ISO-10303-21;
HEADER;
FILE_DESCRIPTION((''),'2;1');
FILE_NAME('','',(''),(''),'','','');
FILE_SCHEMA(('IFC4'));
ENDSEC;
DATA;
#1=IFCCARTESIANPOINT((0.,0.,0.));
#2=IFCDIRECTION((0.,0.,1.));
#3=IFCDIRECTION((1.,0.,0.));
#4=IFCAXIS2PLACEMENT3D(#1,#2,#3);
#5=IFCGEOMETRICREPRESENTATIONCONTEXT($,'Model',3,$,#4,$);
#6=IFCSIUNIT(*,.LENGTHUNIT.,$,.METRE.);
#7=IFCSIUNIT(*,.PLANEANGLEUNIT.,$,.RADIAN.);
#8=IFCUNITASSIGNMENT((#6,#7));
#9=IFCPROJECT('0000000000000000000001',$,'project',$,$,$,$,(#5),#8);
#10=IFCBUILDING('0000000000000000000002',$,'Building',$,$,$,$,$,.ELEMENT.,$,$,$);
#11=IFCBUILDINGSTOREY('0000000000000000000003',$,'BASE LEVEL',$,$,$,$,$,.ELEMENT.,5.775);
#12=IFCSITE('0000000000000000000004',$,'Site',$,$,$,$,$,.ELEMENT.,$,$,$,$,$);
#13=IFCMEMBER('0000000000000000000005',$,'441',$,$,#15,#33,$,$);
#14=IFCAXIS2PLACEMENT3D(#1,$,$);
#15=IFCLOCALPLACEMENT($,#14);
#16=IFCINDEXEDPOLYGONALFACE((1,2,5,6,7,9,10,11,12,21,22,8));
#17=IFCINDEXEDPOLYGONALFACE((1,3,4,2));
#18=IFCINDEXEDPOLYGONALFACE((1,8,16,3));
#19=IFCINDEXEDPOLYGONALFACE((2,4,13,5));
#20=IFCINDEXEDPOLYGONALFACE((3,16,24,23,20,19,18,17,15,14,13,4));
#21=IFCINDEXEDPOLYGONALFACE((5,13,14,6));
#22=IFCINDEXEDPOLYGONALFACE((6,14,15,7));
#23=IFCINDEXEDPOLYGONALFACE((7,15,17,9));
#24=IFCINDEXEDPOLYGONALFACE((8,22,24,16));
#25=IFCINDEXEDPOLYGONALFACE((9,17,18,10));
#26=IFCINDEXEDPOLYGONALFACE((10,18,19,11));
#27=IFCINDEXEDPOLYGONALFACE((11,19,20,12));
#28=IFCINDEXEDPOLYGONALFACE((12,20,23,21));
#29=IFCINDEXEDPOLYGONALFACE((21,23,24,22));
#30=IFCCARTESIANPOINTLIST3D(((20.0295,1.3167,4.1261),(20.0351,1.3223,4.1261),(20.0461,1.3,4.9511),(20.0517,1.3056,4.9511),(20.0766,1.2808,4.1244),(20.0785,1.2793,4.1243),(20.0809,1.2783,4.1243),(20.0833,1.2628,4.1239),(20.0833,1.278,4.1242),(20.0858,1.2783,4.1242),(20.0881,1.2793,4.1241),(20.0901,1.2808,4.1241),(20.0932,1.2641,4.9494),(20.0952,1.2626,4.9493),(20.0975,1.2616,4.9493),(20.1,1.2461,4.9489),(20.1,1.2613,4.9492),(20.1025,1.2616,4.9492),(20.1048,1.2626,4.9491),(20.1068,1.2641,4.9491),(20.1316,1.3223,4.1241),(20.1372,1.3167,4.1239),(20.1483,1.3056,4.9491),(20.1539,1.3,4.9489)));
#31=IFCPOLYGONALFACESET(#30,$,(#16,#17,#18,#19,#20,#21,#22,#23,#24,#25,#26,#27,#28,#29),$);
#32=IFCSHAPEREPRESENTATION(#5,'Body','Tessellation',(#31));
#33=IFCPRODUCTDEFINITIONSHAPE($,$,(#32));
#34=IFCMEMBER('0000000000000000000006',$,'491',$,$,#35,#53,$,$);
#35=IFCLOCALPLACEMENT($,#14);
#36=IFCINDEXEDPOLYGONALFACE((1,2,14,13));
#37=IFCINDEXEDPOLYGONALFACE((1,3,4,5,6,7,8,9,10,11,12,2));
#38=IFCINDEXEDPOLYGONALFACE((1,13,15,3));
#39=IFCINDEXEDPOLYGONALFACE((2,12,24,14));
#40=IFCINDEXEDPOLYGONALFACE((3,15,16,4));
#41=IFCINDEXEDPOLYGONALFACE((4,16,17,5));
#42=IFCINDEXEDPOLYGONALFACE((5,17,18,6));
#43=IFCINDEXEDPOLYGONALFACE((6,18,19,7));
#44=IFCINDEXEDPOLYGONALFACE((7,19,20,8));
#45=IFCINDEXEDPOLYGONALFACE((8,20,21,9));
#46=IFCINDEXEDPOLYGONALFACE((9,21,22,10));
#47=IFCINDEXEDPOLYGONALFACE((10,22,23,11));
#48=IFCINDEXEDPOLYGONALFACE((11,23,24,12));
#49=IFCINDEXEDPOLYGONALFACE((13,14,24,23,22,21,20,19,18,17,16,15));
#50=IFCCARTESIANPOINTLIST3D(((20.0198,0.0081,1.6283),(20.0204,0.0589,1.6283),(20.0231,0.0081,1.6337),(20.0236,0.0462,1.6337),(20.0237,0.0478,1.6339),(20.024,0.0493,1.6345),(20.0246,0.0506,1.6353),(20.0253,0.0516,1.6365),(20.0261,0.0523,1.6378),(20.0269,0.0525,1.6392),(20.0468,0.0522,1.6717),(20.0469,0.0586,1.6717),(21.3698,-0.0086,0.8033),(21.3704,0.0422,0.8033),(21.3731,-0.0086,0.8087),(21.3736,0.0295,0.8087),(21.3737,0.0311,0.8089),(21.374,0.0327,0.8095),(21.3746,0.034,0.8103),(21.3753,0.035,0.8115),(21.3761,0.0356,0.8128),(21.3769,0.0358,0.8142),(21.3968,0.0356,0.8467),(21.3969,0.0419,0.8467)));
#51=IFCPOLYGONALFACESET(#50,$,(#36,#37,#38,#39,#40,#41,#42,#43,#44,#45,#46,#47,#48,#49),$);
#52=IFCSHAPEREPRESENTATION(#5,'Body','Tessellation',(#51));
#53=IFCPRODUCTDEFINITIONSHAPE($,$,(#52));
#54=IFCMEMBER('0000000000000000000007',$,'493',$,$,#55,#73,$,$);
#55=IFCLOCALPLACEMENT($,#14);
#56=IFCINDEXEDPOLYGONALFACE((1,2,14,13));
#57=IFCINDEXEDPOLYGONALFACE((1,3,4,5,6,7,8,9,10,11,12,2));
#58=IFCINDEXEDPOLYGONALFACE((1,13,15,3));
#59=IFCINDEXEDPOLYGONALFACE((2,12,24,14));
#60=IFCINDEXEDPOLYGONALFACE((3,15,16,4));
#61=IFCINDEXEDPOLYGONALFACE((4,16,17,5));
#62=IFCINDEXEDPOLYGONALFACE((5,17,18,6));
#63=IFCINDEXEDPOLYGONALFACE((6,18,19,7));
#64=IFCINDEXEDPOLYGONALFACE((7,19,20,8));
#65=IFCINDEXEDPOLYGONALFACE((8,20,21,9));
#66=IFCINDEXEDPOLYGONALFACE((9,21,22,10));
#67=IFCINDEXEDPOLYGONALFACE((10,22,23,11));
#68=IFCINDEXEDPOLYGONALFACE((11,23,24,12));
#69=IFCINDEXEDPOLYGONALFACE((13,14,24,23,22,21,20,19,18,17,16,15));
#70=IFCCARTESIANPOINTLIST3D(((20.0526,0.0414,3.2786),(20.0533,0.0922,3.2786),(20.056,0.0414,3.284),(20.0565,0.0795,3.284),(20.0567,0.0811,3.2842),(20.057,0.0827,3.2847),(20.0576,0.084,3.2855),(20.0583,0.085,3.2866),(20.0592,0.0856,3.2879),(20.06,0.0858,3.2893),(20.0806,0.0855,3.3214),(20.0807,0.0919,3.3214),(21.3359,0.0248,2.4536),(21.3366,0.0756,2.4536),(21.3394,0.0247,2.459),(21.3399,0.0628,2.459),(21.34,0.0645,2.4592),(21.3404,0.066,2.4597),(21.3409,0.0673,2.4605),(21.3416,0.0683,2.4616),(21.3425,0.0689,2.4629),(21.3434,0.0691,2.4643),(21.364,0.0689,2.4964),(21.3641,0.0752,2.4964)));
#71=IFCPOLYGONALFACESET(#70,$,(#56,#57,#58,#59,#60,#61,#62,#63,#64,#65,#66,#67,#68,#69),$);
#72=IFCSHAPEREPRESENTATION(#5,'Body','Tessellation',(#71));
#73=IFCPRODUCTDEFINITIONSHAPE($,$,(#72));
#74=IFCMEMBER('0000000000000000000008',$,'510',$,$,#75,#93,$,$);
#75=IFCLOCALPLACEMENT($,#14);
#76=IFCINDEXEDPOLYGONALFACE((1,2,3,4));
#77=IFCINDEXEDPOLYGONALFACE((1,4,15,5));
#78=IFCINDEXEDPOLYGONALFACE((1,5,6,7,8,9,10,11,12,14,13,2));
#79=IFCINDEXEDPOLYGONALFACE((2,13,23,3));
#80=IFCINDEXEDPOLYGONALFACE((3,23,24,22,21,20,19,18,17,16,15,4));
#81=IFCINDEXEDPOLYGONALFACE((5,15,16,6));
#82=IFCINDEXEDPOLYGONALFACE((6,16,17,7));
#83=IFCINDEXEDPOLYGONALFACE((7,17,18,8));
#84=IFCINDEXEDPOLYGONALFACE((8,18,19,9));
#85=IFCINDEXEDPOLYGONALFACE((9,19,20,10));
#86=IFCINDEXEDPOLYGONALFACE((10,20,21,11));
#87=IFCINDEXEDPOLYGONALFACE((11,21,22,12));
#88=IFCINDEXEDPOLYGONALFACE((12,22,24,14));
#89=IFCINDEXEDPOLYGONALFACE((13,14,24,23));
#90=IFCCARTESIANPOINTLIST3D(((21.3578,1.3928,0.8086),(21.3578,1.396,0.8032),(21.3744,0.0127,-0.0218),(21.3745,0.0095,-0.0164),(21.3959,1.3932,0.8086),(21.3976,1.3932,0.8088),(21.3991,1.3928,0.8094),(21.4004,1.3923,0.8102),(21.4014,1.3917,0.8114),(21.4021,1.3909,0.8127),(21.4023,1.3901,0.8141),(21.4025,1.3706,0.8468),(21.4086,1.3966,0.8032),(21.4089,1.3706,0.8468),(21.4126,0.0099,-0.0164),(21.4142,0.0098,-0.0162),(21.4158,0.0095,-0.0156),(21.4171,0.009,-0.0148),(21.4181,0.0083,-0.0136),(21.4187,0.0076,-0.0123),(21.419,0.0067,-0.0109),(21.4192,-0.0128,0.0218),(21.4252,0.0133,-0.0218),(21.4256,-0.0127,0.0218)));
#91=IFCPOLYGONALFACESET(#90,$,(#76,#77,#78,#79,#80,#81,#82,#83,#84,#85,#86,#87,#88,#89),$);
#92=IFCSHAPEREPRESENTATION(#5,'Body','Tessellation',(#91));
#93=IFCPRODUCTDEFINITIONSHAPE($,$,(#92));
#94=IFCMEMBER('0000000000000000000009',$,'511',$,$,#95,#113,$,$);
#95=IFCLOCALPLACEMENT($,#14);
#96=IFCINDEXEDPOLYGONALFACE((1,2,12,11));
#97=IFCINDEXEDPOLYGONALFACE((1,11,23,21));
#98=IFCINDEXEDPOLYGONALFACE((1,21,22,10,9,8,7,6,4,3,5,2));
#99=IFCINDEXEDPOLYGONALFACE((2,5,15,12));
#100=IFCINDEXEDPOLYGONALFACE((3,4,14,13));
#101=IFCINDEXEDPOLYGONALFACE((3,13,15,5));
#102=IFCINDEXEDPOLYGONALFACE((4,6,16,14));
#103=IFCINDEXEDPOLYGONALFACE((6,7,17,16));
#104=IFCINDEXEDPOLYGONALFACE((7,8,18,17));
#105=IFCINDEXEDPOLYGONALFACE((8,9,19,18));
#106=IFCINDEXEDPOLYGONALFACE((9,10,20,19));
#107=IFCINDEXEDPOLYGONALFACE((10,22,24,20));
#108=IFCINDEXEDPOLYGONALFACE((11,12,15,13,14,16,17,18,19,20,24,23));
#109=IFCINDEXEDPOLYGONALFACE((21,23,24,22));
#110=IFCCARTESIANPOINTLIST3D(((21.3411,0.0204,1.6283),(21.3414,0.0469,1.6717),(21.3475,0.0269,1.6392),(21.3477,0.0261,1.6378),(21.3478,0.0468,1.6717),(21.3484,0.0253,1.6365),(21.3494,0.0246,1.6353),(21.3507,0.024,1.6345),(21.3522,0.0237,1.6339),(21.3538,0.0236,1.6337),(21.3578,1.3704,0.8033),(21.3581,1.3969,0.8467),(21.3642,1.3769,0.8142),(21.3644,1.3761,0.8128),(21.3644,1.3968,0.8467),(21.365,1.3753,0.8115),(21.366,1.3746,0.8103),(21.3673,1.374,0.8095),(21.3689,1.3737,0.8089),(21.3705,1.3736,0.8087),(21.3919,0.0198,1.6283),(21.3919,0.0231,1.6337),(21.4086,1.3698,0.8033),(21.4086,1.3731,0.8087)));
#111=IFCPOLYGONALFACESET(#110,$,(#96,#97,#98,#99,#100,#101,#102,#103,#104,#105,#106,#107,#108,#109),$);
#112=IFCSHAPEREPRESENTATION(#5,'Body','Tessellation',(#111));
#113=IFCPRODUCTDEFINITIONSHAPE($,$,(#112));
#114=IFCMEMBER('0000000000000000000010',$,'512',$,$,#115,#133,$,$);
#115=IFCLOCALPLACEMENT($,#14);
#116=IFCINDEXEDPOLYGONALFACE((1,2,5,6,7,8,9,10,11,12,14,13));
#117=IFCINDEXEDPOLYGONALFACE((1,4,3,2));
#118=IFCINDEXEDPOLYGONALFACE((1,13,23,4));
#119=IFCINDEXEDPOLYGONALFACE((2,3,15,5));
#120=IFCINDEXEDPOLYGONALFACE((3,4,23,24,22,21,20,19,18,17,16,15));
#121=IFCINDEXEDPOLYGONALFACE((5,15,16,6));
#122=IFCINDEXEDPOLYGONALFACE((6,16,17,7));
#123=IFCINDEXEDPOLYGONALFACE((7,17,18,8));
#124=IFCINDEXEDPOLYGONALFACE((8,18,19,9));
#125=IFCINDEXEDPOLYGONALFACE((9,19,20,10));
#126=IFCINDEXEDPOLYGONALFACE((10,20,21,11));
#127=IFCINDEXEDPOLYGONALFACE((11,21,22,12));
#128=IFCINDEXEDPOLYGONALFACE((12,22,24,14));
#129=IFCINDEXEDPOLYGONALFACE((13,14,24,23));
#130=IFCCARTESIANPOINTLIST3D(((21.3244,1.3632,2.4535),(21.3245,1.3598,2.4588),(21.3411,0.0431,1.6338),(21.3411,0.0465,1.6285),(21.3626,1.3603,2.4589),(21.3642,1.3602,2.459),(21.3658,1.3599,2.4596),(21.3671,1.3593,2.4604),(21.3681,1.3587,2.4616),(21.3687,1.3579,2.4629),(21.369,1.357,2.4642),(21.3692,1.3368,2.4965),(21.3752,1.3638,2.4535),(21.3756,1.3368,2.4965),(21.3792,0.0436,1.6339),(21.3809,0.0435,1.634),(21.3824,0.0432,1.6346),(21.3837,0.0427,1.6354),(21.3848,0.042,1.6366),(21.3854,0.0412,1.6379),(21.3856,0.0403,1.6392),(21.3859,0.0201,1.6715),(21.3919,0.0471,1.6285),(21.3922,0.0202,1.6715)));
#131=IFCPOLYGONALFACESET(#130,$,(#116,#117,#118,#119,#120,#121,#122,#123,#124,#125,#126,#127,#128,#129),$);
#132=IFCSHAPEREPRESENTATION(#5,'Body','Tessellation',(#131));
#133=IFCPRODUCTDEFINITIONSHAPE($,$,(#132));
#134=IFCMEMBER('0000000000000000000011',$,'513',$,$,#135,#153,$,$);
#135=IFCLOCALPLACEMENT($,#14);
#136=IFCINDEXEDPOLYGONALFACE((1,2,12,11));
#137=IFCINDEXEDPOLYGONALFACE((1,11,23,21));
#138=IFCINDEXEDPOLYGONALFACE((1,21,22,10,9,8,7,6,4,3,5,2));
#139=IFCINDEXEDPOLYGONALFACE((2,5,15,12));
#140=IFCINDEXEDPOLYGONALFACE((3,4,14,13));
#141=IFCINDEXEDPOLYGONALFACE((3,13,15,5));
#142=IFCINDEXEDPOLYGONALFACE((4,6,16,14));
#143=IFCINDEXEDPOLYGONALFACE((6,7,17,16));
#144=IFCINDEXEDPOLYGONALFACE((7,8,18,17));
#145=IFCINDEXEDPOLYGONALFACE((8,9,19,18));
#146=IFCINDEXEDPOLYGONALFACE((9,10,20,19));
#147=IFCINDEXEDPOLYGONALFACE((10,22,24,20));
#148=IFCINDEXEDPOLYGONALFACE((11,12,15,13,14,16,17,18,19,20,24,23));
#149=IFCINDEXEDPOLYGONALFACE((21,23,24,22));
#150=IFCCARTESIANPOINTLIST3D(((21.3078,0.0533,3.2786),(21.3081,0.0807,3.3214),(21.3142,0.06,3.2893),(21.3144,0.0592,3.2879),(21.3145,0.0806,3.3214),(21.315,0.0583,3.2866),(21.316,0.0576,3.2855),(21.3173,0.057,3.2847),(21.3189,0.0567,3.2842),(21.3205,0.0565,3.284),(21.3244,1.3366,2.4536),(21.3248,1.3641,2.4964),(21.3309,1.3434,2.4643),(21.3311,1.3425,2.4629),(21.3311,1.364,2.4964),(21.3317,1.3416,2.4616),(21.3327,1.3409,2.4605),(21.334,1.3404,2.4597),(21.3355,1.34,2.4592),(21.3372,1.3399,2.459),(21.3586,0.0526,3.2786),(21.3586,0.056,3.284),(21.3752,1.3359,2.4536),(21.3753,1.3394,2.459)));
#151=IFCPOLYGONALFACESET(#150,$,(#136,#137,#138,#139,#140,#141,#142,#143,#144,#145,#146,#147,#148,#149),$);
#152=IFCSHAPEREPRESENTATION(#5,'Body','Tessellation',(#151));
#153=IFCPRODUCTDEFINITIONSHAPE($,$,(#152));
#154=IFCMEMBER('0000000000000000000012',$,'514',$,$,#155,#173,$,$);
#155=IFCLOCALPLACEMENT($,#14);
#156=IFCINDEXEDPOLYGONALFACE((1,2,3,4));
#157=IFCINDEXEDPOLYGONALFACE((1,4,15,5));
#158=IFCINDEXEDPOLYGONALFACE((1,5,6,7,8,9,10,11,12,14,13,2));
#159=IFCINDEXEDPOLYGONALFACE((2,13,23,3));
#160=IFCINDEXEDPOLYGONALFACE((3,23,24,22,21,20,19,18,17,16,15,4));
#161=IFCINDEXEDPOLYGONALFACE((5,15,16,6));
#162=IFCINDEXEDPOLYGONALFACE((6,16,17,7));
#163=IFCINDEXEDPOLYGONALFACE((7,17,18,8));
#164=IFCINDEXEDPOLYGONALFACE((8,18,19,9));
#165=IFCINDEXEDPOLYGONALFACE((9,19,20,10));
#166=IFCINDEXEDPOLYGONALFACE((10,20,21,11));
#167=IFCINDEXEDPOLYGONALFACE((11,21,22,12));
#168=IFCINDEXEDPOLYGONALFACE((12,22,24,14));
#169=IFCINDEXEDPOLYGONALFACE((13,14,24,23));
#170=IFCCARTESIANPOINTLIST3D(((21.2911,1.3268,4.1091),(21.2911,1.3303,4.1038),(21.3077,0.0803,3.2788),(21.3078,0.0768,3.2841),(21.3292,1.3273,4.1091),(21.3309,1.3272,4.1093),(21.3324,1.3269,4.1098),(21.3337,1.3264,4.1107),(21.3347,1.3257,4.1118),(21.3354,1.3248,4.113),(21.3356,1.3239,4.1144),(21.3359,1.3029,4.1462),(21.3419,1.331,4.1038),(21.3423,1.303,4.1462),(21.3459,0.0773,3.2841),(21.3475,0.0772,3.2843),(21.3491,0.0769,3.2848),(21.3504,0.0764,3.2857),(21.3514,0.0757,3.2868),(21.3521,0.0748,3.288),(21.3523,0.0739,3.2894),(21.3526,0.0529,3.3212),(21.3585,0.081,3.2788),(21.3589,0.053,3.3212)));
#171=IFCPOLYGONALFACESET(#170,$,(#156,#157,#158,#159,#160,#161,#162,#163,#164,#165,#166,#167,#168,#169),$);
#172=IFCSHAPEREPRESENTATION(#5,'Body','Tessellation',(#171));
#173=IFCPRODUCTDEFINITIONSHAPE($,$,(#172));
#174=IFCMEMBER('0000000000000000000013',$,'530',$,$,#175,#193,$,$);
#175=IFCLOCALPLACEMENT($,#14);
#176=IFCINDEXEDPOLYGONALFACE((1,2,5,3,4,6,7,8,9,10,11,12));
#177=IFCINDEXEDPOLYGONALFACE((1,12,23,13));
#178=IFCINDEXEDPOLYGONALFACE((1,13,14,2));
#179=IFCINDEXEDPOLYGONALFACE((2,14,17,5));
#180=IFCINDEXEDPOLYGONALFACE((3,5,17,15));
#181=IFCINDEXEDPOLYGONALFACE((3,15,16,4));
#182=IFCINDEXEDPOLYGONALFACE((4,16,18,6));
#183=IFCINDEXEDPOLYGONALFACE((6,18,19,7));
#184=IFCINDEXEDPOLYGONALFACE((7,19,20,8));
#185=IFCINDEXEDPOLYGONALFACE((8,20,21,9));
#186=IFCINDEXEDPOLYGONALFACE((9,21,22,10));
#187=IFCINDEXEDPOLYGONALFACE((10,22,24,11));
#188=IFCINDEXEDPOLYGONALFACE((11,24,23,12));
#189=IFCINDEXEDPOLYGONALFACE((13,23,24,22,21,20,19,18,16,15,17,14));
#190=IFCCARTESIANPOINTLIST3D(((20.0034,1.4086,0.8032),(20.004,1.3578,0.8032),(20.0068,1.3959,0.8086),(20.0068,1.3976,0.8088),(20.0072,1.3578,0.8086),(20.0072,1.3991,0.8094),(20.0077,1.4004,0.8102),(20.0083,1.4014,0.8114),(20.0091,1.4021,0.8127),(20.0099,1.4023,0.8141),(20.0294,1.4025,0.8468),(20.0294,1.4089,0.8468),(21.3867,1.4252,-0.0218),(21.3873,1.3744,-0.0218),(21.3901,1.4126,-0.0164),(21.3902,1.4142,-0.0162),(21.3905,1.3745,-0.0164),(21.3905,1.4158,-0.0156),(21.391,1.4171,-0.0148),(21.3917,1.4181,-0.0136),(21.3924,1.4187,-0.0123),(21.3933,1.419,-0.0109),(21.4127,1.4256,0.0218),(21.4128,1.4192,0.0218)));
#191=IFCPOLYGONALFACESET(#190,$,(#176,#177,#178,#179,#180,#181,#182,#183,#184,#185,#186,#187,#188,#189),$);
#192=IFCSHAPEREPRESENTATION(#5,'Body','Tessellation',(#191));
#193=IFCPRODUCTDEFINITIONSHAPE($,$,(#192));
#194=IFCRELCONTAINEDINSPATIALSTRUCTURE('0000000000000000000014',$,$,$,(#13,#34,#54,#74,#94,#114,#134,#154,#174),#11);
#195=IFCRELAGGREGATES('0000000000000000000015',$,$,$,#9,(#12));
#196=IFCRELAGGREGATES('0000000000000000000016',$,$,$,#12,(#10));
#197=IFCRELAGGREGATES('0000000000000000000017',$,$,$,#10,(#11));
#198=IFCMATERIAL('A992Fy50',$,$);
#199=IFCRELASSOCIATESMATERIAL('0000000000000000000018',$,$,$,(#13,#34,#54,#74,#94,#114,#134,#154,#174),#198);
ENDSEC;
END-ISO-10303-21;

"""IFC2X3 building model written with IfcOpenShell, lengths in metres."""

from ifc_helpers import new_model, si_unit, frame, origin_with_axes, origin_2d_with_axis, place, context, project, spatial, l_section, extrude, material, element, save


model = new_model("IFC2X3")

# Units and contexts
model_context = context("Model", 3, world=origin_with_axes())
ifc_project = project(units=[si_unit("LENGTHUNIT", "METRE"), si_unit("PLANEANGLEUNIT", "RADIAN")], contexts=[model_context])

# Site, building, storey
site = spatial("IfcSite", under=ifc_project, Name="Site", CompositionType="ELEMENT")
building = spatial("IfcBuilding", under=site, Name="Building", CompositionType="ELEMENT")
storey = spatial("IfcBuildingStorey", under=building, Name="BASE LEVEL", CompositionType="ELEMENT", Elevation=5.775)

# Members
ifc_material = material(Name="A992Fy50")
for number, where, z_axis, x_axis, name in (
    (1, (20.0833, 1.3167, 4.125), (0.020194, -0.020194, 0.999592), (0.707107, 0.707107, 0.0), "441"),
):
    element("IfcMember", number, at=place(None, frame(where, z_axis=z_axis, x_axis=x_axis)), inside=storey, material=ifc_material, Name=name, context=model_context, shape_type="SweptSolid", body=[
        extrude(l_section(Depth=0.0762, Width=0.0762, Thickness=0.0079, FilletRadius=0.0096, at=origin_2d_with_axis()), origin_with_axes(), (0.0, 0.0, 1.0), 0.8253),
    ])
member_1_placement = place(None, frame((21.3833, 0.0167, 0.825), z_axis=(-0.853234, 0.010534, 0.521421), x_axis=(-0.012345, -0.999924, 0.0)))
element("IfcMember", 2, at=member_1_placement, inside=storey, material=ifc_material, Name="491", context=model_context, shape_type="SweptSolid", body=[
    extrude(l_section(Depth=0.0508, Width=0.0508, Thickness=0.0063, FilletRadius=0.0063, at=origin_2d_with_axis()), origin_with_axes(), (0.0, 0.0, 1.0), 1.5822),
])
member_2_placement = place(None, frame((21.35, 0.05, 2.475), z_axis=(-0.841128, 0.010924, 0.540725), x_axis=(-0.012345, -0.999924, 0.0)))
element("IfcMember", 3, at=member_2_placement, inside=storey, material=ifc_material, Name="493", context=model_context, shape_type="SweptSolid", body=[
    extrude(l_section(Depth=0.0508, Width=0.0508, Thickness=0.0063, FilletRadius=0.0063, at=origin_2d_with_axis()), origin_with_axes(), (0.0, 0.0, 1.0), 1.5257),
])
member_3_placement = place(None, frame((21.4, 0.0, 0.0), z_axis=(-0.010347, 0.858813, 0.512184), x_axis=(-0.999927, -0.012047, 0.0)))
element("IfcMember", 4, at=member_3_placement, inside=storey, material=ifc_material, Name="510", context=model_context, shape_type="SweptSolid", body=[
    extrude(l_section(Depth=0.0508, Width=0.0508, Thickness=0.0063, FilletRadius=0.0063, at=origin_2d_with_axis()), origin_with_axes(), (0.0, 0.0, 1.0), 1.6107),
])
member_4_placement = place(None, frame((21.3833, 1.3833, 0.825), z_axis=(-0.010534, -0.853234, 0.521421), x_axis=(0.999924, -0.012345, 0.0)))
element("IfcMember", 5, at=member_4_placement, inside=storey, material=ifc_material, Name="511", context=model_context, shape_type="SweptSolid", body=[
    extrude(l_section(Depth=0.0508, Width=0.0508, Thickness=0.0063, FilletRadius=0.0063, at=origin_2d_with_axis()), origin_with_axes(), (0.0, 0.0, 1.0), 1.5822),
])
member_5_placement = place(None, frame((21.3667, 0.0333, 1.65), z_axis=(-0.010726, 0.847346, 0.530932), x_axis=(-0.999927, -0.012047, 0.0)))
element("IfcMember", 6, at=member_5_placement, inside=storey, material=ifc_material, Name="512", context=model_context, shape_type="SweptSolid", body=[
    extrude(l_section(Depth=0.0508, Width=0.0508, Thickness=0.0063, FilletRadius=0.0063, at=origin_2d_with_axis()), origin_with_axes(), (0.0, 0.0, 1.0), 1.5539),
])
member_6_placement = place(None, frame((21.35, 1.35, 2.475), z_axis=(-0.010924, -0.841128, 0.540725), x_axis=(0.999924, -0.012345, 0.0)))
element("IfcMember", 7, at=member_6_placement, inside=storey, material=ifc_material, Name="513", context=model_context, shape_type="SweptSolid", body=[
    extrude(l_section(Depth=0.0508, Width=0.0508, Thickness=0.0063, FilletRadius=0.0063, at=origin_2d_with_axis()), origin_with_axes(), (0.0, 0.0, 1.0), 1.5257),
])
member_7_placement = place(None, frame((21.3333, 0.0667, 3.3), z_axis=(-0.011127, 0.834558, 0.550808), x_axis=(-0.999911, -0.013332, 0.0)))
element("IfcMember", 8, at=member_7_placement, inside=storey, material=ifc_material, Name="514", context=model_context, shape_type="SweptSolid", body=[
    extrude(l_section(Depth=0.0508, Width=0.0508, Thickness=0.0063, FilletRadius=0.0063, at=origin_2d_with_axis()), origin_with_axes(), (0.0, 0.0, 1.0), 1.4978),
])
member_8_placement = place(None, frame((21.4, 1.4, 0.0), z_axis=(-0.858813, -0.010347, 0.512184), x_axis=(0.012047, -0.999927, 0.0)))
element("IfcMember", 9, at=member_8_placement, inside=storey, material=ifc_material, Name="530", context=model_context, shape_type="SweptSolid", body=[
    extrude(l_section(Depth=0.0508, Width=0.0508, Thickness=0.0063, FilletRadius=0.0063, at=origin_2d_with_axis()), origin_with_axes(), (0.0, 0.0, 1.0), 1.6107),
])

save(model, "model.ifc")
